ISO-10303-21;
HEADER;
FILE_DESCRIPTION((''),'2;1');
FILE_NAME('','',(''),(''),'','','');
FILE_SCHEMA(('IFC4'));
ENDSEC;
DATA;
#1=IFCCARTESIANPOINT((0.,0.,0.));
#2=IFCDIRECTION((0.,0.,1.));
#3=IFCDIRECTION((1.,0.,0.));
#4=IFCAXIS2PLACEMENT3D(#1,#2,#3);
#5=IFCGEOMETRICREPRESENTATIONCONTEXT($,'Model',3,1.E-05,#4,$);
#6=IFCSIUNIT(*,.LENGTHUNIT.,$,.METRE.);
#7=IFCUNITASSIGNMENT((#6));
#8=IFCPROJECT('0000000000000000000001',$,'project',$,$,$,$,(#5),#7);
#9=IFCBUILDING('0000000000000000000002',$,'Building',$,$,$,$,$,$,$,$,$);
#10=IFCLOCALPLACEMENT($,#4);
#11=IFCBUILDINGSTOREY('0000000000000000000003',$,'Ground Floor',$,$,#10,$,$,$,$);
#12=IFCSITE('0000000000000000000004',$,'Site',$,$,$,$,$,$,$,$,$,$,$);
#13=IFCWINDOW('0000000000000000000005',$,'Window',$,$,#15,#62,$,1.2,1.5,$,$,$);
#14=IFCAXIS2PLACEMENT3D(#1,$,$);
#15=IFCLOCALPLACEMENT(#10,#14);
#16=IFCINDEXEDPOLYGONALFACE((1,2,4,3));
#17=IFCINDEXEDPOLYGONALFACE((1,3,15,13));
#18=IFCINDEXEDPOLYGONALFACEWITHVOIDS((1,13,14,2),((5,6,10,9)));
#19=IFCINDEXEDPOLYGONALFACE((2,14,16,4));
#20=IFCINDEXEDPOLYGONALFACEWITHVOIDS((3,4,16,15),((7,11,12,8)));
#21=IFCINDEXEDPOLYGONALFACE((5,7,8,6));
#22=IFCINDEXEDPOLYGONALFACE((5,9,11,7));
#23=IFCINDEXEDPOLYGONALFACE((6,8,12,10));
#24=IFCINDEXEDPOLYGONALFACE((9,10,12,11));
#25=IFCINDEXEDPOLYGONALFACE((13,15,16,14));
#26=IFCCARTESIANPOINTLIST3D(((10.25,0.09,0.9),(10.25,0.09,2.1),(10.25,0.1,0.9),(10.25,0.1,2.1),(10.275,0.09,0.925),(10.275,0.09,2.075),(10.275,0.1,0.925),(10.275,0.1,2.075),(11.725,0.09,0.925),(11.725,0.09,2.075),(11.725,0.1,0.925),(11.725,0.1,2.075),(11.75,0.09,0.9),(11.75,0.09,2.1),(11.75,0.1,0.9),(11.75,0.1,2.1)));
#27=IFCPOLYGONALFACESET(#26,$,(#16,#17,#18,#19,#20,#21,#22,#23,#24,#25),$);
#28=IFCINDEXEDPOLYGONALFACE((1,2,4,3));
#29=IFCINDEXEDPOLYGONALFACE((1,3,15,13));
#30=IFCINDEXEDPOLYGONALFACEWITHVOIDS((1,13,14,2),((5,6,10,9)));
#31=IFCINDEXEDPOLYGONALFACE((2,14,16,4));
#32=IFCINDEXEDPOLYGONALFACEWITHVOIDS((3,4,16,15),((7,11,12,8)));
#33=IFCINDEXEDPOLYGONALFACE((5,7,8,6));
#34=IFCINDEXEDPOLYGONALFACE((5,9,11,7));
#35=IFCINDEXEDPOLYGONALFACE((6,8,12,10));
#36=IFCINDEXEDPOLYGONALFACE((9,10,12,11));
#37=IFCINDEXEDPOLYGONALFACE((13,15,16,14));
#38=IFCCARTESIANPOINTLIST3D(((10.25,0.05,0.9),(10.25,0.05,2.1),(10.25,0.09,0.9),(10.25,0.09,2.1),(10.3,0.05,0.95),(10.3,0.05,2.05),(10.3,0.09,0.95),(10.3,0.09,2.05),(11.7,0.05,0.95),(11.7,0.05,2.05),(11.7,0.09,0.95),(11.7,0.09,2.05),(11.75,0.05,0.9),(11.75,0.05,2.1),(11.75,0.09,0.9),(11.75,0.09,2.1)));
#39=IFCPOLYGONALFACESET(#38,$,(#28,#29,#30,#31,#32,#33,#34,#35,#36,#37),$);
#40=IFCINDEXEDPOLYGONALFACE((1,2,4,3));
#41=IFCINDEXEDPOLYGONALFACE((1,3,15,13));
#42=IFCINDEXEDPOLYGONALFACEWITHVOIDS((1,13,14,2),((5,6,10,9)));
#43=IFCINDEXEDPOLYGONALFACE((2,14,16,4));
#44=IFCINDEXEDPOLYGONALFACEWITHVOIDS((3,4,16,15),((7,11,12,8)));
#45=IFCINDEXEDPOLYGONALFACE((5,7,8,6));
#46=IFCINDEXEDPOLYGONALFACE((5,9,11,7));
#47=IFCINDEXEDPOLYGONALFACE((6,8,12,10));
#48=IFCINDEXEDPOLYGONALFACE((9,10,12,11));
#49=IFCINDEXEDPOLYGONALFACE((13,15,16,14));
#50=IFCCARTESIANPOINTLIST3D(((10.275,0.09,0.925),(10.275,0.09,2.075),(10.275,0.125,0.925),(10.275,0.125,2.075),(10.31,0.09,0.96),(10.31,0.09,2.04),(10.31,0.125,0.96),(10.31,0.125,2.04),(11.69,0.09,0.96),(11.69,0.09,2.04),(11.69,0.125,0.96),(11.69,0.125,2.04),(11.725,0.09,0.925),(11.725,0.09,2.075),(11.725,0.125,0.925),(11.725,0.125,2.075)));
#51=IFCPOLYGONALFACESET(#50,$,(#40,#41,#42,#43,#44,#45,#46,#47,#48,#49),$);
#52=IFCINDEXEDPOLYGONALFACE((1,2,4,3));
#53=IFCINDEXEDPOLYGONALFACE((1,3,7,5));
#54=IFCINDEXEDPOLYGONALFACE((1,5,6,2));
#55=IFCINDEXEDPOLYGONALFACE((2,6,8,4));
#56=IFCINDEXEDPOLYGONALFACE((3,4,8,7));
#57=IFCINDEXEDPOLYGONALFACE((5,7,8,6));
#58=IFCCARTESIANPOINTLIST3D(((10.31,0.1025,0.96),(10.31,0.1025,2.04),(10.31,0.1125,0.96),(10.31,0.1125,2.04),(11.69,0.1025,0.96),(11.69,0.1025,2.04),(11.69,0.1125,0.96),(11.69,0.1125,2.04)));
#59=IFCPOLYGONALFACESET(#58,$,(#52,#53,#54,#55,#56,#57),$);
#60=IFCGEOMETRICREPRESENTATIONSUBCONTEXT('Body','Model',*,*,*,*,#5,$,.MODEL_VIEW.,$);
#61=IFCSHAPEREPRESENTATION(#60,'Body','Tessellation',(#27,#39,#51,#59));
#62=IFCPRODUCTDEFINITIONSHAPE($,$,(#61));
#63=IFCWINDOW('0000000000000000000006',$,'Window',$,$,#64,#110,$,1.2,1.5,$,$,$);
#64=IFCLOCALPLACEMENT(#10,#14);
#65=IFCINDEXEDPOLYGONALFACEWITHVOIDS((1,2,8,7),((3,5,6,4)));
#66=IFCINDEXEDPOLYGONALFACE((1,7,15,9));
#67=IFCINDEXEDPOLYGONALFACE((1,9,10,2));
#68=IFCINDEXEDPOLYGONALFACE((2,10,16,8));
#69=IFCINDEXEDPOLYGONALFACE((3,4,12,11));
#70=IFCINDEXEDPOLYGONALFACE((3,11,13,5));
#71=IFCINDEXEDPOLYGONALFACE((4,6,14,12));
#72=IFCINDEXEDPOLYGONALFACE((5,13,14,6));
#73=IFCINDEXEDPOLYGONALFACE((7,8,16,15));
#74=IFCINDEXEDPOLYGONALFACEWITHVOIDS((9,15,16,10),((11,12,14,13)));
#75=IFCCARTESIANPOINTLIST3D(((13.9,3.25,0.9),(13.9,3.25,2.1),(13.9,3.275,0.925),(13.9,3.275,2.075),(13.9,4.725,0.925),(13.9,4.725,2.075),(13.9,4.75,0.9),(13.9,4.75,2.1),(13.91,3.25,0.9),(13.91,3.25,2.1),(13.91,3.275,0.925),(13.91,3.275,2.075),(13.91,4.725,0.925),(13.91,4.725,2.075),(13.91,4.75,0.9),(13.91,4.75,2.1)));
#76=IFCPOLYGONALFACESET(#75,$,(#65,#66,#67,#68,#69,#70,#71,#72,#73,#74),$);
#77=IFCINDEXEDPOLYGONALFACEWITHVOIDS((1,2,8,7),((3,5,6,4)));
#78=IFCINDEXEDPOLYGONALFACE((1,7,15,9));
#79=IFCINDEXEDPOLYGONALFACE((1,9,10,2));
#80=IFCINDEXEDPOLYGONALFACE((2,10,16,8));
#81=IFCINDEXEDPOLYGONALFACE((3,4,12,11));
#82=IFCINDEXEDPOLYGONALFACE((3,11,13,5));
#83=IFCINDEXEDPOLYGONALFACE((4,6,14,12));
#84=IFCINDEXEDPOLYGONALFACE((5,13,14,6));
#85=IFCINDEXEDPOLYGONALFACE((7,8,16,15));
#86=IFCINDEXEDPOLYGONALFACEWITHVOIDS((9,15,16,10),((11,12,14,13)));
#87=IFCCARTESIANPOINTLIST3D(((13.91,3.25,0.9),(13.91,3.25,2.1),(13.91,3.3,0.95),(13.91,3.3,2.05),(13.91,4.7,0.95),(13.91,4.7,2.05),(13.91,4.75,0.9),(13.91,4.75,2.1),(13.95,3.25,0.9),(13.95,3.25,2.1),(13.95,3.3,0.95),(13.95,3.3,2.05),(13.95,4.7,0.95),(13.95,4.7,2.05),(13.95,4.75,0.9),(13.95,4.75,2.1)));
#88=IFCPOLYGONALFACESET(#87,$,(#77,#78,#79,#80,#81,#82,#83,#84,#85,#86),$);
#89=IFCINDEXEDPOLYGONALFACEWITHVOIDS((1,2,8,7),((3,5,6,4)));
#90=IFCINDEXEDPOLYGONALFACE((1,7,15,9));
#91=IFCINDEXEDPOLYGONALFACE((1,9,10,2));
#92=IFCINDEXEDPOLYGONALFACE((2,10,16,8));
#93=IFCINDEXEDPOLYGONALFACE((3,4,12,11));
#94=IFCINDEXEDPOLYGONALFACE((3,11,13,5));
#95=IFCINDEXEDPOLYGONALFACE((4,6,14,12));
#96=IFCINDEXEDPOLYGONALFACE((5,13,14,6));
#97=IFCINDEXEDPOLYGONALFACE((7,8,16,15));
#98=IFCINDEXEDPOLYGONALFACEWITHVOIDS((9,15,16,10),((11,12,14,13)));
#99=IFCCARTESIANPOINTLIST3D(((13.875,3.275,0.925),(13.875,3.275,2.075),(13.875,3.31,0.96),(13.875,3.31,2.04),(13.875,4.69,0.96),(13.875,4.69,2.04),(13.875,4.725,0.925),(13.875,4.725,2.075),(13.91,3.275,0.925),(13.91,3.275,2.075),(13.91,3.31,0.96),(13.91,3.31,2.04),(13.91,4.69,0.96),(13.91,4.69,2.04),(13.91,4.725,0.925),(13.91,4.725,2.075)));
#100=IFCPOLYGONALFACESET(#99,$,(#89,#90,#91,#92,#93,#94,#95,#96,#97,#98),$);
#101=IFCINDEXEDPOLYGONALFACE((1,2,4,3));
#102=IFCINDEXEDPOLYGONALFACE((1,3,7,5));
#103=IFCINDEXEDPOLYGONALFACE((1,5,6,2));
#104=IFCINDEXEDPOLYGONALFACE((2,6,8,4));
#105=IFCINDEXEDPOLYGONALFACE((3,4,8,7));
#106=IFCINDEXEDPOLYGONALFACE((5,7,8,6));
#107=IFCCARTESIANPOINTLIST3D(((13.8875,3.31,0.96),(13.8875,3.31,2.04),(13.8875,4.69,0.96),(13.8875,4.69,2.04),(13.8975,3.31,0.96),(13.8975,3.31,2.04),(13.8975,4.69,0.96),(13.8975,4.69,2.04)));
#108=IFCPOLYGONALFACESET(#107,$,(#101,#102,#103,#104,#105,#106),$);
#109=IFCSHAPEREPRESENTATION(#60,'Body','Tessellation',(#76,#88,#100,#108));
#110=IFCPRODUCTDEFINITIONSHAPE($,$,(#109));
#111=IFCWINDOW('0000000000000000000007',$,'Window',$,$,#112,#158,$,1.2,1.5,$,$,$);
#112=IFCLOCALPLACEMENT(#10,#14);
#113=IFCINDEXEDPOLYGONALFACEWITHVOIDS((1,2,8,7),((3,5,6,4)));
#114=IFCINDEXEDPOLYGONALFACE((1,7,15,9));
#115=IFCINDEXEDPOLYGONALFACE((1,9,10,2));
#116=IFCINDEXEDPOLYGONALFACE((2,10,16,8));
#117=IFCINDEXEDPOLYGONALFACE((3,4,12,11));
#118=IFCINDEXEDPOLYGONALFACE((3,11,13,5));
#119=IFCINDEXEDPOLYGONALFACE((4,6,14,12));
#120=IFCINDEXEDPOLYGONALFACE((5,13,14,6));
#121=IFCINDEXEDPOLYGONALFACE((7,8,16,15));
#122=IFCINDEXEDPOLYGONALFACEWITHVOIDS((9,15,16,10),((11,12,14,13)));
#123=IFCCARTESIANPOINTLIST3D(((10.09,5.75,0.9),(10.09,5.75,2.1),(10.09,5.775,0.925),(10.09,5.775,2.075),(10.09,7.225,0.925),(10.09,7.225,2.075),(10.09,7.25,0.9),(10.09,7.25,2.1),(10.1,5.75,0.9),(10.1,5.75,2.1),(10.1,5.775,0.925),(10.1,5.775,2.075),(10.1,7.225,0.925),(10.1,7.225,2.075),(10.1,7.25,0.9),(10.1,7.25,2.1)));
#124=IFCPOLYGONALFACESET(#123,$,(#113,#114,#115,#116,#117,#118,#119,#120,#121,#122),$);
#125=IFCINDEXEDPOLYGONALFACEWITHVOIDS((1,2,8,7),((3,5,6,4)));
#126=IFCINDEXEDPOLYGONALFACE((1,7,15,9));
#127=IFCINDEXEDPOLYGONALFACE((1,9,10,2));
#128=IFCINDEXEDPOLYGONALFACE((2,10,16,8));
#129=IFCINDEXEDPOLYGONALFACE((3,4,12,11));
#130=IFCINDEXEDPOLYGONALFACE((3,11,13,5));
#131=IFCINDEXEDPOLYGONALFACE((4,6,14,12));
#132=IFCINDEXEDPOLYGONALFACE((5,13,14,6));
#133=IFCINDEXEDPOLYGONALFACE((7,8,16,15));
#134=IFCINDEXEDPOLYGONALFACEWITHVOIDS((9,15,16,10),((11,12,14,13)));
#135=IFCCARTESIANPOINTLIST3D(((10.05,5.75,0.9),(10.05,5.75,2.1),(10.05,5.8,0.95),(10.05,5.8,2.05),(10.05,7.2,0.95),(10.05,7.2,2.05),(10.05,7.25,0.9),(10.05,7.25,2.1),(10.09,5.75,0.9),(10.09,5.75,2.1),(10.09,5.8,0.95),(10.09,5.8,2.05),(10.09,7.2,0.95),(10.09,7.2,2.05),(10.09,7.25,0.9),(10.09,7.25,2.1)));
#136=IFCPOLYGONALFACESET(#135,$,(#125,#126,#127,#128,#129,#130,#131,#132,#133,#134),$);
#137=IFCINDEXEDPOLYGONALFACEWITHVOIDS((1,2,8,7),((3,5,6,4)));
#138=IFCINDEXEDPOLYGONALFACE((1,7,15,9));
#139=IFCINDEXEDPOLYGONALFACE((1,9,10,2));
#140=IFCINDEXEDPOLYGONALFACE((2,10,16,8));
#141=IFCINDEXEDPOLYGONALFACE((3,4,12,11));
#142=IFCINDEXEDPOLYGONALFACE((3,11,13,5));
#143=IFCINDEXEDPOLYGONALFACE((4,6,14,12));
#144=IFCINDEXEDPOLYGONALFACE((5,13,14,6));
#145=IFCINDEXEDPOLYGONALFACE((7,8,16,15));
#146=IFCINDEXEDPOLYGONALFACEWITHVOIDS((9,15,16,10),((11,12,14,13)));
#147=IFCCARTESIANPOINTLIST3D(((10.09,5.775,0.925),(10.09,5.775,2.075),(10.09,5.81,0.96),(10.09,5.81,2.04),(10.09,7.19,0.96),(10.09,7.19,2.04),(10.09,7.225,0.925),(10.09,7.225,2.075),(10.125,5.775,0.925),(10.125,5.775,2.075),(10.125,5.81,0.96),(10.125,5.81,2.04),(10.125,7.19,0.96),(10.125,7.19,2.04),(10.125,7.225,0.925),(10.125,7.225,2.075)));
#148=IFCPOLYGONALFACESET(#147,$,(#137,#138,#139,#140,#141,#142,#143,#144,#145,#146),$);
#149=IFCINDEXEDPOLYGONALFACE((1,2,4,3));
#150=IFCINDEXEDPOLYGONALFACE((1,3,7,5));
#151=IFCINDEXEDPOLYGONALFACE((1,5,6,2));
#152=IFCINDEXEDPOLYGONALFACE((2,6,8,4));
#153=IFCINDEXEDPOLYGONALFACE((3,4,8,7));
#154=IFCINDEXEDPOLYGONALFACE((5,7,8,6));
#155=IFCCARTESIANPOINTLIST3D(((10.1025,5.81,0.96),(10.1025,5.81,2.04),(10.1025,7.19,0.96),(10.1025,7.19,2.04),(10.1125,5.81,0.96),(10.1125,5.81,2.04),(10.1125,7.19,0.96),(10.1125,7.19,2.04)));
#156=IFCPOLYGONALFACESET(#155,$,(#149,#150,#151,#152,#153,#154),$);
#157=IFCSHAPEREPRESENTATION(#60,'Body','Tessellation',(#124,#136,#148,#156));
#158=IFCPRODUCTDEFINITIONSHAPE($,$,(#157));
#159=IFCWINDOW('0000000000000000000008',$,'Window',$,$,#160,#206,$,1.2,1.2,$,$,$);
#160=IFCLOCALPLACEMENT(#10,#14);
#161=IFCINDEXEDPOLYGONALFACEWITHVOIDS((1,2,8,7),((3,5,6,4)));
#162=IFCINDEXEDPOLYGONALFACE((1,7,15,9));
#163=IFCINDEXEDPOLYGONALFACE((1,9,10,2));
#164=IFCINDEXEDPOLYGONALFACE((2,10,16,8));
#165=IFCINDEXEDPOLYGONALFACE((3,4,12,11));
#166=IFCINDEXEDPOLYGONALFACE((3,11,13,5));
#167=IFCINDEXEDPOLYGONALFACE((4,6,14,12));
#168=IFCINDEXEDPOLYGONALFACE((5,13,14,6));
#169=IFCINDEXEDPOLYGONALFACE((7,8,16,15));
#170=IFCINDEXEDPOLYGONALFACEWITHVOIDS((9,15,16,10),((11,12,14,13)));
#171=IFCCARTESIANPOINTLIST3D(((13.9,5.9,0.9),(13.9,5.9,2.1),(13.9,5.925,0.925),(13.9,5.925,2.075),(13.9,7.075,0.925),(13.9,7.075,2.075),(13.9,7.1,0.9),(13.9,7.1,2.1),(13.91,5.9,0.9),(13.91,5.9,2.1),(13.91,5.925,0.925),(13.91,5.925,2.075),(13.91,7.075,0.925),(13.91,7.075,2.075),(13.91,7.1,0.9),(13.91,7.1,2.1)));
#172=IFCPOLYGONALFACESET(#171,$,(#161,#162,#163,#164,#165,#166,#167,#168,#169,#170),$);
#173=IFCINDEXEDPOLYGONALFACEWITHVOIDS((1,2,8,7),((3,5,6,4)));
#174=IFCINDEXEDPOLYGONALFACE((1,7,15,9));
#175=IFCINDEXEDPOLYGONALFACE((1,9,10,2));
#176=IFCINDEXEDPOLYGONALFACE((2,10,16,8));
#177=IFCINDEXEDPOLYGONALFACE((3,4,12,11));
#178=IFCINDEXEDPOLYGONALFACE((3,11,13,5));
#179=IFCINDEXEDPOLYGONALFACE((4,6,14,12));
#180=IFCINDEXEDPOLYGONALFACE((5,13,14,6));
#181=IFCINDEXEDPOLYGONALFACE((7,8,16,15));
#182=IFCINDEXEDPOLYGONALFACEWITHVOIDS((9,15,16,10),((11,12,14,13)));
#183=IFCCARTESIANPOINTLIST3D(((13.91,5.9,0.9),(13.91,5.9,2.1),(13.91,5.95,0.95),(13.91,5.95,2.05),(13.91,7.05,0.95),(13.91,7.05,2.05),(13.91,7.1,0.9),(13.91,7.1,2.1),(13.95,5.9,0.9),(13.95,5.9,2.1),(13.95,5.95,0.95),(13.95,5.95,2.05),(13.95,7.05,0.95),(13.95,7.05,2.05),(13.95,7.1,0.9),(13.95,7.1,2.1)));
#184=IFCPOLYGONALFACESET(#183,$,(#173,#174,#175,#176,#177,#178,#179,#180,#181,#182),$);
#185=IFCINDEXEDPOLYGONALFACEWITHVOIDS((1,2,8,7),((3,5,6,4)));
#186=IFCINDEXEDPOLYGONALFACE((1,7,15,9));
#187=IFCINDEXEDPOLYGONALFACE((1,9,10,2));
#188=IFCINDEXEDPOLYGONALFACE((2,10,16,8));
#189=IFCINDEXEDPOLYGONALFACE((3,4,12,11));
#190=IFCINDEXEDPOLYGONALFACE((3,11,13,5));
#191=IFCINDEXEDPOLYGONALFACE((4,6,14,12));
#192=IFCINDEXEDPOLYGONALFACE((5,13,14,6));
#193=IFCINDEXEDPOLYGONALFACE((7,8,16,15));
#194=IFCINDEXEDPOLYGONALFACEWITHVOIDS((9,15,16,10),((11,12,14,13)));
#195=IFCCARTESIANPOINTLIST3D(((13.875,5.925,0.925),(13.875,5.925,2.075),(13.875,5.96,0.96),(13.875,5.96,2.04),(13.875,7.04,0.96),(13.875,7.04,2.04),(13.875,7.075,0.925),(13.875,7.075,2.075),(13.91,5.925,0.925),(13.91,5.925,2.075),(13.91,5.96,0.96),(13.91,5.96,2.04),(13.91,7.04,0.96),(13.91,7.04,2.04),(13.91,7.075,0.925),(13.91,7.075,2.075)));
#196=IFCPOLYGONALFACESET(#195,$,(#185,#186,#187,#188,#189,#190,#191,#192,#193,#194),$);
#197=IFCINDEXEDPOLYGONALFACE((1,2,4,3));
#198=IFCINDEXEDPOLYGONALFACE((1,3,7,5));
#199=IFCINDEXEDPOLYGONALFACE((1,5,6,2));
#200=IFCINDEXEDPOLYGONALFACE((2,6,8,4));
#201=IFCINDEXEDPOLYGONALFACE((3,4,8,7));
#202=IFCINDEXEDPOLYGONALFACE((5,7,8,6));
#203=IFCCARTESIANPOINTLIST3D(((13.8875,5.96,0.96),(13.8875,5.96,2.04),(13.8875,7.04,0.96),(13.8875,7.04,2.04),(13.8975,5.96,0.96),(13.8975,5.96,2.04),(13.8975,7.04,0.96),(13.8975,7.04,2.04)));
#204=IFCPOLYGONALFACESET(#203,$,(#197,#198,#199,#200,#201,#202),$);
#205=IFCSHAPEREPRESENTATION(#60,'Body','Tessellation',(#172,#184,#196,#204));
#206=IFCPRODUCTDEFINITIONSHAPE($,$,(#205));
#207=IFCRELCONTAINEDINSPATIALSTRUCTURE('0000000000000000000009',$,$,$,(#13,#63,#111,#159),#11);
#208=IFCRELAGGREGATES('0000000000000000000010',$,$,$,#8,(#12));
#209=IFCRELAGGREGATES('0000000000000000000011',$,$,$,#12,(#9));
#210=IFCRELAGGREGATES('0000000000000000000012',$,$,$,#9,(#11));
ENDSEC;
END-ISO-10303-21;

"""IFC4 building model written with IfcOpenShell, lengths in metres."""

from ifc_helpers import new_model, si_unit, frame, origin_with_axes, place, context, subcontext, project, spatial, line, indexed_curve, outline, extrude, element, save


model = new_model("IFC4")

# Units and contexts
model_context = context("Model", 3, precision=1e-05, world=origin_with_axes())
body_context = subcontext(model_context, "Body", "Model", "MODEL_VIEW")
ifc_project = project(units=[si_unit("LENGTHUNIT", "METRE")], contexts=[model_context])

# Site, building, storey
site = spatial("IfcSite", under=ifc_project, Name="Site")
building = spatial("IfcBuilding", under=site, Name="Building")
storey_placement = place(None, origin_with_axes())
storey = spatial("IfcBuildingStorey", under=building, at=storey_placement, Name="Ground Floor")

# Windows
for number, where, z_axis, x_axis, name in (
    (1, (10.25, 0.0, 0.9), (0.0, 0.0, 1.0), (1.0, 0.0, 0.0), "Window"),
    (2, (14.0, 3.25, 0.9), (0.0, 0.0, 1.0), (0.0, 1.0, 0.0), "Window"),
    (3, (10.0, 7.25, 0.9), (0.0, 0.0, 1.0), (0.0, -1.0, 0.0), "Window"),
):
    element("IfcWindow", number, at=place(storey_placement, frame(where, z_axis=z_axis, x_axis=x_axis)), inside=storey, Name=name, OverallHeight=1.2, OverallWidth=1.5, context=body_context, shape_type="SweptSolid", body=[
        extrude(outline(indexed_curve([(0.0, 0.0), (1.5, 0.0), (1.5, 1.2), (0.0, 1.2)], segments=[line(1, 2, 3, 4, 1)]), holes=[indexed_curve([(0.025, 0.025), (1.475, 0.025), (1.475, 1.175), (0.025, 1.175)], segments=[line(1, 2, 3, 4, 1)])]), frame((0.0, 0.09, 0.0), z_axis=(0.0, -1.0, 0.0), x_axis=(1.0, 0.0, 0.0)), (0.0, 0.0, -1.0), 0.01),
        extrude(outline(indexed_curve([(0.0, 0.0), (1.5, 0.0), (1.5, 1.2), (0.0, 1.2)], segments=[line(1, 2, 3, 4, 1)]), holes=[indexed_curve([(0.05, 0.05), (1.45, 0.05), (1.45, 1.15), (0.05, 1.15)], segments=[line(1, 2, 3, 4, 1)])]), frame((0.0, 0.05, 0.0), z_axis=(0.0, -1.0, 0.0), x_axis=(1.0, 0.0, 0.0)), (0.0, 0.0, -1.0), 0.04),
        extrude(outline(indexed_curve([(0.0, 0.0), (1.45, 0.0), (1.45, 1.15), (0.0, 1.15)], segments=[line(1, 2, 3, 4, 1)]), holes=[indexed_curve([(0.035, 0.035), (1.415, 0.035), (1.415, 1.115), (0.035, 1.115)], segments=[line(1, 2, 3, 4, 1)])]), frame((0.025, 0.09, 0.025), z_axis=(0.0, -1.0, 0.0), x_axis=(1.0, 0.0, 0.0)), (0.0, 0.0, -1.0), 0.035),
        extrude(outline(indexed_curve([(0.035, 0.035), (1.415, 0.035), (1.415, 1.115), (0.035, 1.115)], segments=[line(1, 2, 3, 4, 1)])), frame((0.025, 0.1025, 0.025), z_axis=(0.0, -1.0, 0.0), x_axis=(1.0, 0.0, 0.0)), (0.0, 0.0, -1.0), 0.01),
    ])
window_1_placement = place(storey_placement, frame((14.0, 5.9, 0.9), z_axis=(0.0, 0.0, 1.0), x_axis=(0.0, 1.0, 0.0)))
element("IfcWindow", 4, at=window_1_placement, inside=storey, Name="Window", OverallHeight=1.2, OverallWidth=1.2, context=body_context, shape_type="SweptSolid", body=[
    extrude(outline(indexed_curve([(0.0, 0.0), (1.2, 0.0), (1.2, 1.2), (0.0, 1.2)], segments=[line(1, 2, 3, 4, 1)]), holes=[indexed_curve([(0.025, 0.025), (1.175, 0.025), (1.175, 1.175), (0.025, 1.175)], segments=[line(1, 2, 3, 4, 1)])]), frame((0.0, 0.09, 0.0), z_axis=(0.0, -1.0, 0.0), x_axis=(1.0, 0.0, 0.0)), (0.0, 0.0, -1.0), 0.01),
    extrude(outline(indexed_curve([(0.0, 0.0), (1.2, 0.0), (1.2, 1.2), (0.0, 1.2)], segments=[line(1, 2, 3, 4, 1)]), holes=[indexed_curve([(0.05, 0.05), (1.15, 0.05), (1.15, 1.15), (0.05, 1.15)], segments=[line(1, 2, 3, 4, 1)])]), frame((0.0, 0.05, 0.0), z_axis=(0.0, -1.0, 0.0), x_axis=(1.0, 0.0, 0.0)), (0.0, 0.0, -1.0), 0.04),
    extrude(outline(indexed_curve([(0.0, 0.0), (1.15, 0.0), (1.15, 1.15), (0.0, 1.15)], segments=[line(1, 2, 3, 4, 1)]), holes=[indexed_curve([(0.035, 0.035), (1.115, 0.035), (1.115, 1.115), (0.035, 1.115)], segments=[line(1, 2, 3, 4, 1)])]), frame((0.025, 0.09, 0.025), z_axis=(0.0, -1.0, 0.0), x_axis=(1.0, 0.0, 0.0)), (0.0, 0.0, -1.0), 0.035),
    extrude(outline(indexed_curve([(0.035, 0.035), (1.115, 0.035), (1.115, 1.115), (0.035, 1.115)], segments=[line(1, 2, 3, 4, 1)])), frame((0.025, 0.1025, 0.025), z_axis=(0.0, -1.0, 0.0), x_axis=(1.0, 0.0, 0.0)), (0.0, 0.0, -1.0), 0.01),
])

save(model, "model.ifc")
